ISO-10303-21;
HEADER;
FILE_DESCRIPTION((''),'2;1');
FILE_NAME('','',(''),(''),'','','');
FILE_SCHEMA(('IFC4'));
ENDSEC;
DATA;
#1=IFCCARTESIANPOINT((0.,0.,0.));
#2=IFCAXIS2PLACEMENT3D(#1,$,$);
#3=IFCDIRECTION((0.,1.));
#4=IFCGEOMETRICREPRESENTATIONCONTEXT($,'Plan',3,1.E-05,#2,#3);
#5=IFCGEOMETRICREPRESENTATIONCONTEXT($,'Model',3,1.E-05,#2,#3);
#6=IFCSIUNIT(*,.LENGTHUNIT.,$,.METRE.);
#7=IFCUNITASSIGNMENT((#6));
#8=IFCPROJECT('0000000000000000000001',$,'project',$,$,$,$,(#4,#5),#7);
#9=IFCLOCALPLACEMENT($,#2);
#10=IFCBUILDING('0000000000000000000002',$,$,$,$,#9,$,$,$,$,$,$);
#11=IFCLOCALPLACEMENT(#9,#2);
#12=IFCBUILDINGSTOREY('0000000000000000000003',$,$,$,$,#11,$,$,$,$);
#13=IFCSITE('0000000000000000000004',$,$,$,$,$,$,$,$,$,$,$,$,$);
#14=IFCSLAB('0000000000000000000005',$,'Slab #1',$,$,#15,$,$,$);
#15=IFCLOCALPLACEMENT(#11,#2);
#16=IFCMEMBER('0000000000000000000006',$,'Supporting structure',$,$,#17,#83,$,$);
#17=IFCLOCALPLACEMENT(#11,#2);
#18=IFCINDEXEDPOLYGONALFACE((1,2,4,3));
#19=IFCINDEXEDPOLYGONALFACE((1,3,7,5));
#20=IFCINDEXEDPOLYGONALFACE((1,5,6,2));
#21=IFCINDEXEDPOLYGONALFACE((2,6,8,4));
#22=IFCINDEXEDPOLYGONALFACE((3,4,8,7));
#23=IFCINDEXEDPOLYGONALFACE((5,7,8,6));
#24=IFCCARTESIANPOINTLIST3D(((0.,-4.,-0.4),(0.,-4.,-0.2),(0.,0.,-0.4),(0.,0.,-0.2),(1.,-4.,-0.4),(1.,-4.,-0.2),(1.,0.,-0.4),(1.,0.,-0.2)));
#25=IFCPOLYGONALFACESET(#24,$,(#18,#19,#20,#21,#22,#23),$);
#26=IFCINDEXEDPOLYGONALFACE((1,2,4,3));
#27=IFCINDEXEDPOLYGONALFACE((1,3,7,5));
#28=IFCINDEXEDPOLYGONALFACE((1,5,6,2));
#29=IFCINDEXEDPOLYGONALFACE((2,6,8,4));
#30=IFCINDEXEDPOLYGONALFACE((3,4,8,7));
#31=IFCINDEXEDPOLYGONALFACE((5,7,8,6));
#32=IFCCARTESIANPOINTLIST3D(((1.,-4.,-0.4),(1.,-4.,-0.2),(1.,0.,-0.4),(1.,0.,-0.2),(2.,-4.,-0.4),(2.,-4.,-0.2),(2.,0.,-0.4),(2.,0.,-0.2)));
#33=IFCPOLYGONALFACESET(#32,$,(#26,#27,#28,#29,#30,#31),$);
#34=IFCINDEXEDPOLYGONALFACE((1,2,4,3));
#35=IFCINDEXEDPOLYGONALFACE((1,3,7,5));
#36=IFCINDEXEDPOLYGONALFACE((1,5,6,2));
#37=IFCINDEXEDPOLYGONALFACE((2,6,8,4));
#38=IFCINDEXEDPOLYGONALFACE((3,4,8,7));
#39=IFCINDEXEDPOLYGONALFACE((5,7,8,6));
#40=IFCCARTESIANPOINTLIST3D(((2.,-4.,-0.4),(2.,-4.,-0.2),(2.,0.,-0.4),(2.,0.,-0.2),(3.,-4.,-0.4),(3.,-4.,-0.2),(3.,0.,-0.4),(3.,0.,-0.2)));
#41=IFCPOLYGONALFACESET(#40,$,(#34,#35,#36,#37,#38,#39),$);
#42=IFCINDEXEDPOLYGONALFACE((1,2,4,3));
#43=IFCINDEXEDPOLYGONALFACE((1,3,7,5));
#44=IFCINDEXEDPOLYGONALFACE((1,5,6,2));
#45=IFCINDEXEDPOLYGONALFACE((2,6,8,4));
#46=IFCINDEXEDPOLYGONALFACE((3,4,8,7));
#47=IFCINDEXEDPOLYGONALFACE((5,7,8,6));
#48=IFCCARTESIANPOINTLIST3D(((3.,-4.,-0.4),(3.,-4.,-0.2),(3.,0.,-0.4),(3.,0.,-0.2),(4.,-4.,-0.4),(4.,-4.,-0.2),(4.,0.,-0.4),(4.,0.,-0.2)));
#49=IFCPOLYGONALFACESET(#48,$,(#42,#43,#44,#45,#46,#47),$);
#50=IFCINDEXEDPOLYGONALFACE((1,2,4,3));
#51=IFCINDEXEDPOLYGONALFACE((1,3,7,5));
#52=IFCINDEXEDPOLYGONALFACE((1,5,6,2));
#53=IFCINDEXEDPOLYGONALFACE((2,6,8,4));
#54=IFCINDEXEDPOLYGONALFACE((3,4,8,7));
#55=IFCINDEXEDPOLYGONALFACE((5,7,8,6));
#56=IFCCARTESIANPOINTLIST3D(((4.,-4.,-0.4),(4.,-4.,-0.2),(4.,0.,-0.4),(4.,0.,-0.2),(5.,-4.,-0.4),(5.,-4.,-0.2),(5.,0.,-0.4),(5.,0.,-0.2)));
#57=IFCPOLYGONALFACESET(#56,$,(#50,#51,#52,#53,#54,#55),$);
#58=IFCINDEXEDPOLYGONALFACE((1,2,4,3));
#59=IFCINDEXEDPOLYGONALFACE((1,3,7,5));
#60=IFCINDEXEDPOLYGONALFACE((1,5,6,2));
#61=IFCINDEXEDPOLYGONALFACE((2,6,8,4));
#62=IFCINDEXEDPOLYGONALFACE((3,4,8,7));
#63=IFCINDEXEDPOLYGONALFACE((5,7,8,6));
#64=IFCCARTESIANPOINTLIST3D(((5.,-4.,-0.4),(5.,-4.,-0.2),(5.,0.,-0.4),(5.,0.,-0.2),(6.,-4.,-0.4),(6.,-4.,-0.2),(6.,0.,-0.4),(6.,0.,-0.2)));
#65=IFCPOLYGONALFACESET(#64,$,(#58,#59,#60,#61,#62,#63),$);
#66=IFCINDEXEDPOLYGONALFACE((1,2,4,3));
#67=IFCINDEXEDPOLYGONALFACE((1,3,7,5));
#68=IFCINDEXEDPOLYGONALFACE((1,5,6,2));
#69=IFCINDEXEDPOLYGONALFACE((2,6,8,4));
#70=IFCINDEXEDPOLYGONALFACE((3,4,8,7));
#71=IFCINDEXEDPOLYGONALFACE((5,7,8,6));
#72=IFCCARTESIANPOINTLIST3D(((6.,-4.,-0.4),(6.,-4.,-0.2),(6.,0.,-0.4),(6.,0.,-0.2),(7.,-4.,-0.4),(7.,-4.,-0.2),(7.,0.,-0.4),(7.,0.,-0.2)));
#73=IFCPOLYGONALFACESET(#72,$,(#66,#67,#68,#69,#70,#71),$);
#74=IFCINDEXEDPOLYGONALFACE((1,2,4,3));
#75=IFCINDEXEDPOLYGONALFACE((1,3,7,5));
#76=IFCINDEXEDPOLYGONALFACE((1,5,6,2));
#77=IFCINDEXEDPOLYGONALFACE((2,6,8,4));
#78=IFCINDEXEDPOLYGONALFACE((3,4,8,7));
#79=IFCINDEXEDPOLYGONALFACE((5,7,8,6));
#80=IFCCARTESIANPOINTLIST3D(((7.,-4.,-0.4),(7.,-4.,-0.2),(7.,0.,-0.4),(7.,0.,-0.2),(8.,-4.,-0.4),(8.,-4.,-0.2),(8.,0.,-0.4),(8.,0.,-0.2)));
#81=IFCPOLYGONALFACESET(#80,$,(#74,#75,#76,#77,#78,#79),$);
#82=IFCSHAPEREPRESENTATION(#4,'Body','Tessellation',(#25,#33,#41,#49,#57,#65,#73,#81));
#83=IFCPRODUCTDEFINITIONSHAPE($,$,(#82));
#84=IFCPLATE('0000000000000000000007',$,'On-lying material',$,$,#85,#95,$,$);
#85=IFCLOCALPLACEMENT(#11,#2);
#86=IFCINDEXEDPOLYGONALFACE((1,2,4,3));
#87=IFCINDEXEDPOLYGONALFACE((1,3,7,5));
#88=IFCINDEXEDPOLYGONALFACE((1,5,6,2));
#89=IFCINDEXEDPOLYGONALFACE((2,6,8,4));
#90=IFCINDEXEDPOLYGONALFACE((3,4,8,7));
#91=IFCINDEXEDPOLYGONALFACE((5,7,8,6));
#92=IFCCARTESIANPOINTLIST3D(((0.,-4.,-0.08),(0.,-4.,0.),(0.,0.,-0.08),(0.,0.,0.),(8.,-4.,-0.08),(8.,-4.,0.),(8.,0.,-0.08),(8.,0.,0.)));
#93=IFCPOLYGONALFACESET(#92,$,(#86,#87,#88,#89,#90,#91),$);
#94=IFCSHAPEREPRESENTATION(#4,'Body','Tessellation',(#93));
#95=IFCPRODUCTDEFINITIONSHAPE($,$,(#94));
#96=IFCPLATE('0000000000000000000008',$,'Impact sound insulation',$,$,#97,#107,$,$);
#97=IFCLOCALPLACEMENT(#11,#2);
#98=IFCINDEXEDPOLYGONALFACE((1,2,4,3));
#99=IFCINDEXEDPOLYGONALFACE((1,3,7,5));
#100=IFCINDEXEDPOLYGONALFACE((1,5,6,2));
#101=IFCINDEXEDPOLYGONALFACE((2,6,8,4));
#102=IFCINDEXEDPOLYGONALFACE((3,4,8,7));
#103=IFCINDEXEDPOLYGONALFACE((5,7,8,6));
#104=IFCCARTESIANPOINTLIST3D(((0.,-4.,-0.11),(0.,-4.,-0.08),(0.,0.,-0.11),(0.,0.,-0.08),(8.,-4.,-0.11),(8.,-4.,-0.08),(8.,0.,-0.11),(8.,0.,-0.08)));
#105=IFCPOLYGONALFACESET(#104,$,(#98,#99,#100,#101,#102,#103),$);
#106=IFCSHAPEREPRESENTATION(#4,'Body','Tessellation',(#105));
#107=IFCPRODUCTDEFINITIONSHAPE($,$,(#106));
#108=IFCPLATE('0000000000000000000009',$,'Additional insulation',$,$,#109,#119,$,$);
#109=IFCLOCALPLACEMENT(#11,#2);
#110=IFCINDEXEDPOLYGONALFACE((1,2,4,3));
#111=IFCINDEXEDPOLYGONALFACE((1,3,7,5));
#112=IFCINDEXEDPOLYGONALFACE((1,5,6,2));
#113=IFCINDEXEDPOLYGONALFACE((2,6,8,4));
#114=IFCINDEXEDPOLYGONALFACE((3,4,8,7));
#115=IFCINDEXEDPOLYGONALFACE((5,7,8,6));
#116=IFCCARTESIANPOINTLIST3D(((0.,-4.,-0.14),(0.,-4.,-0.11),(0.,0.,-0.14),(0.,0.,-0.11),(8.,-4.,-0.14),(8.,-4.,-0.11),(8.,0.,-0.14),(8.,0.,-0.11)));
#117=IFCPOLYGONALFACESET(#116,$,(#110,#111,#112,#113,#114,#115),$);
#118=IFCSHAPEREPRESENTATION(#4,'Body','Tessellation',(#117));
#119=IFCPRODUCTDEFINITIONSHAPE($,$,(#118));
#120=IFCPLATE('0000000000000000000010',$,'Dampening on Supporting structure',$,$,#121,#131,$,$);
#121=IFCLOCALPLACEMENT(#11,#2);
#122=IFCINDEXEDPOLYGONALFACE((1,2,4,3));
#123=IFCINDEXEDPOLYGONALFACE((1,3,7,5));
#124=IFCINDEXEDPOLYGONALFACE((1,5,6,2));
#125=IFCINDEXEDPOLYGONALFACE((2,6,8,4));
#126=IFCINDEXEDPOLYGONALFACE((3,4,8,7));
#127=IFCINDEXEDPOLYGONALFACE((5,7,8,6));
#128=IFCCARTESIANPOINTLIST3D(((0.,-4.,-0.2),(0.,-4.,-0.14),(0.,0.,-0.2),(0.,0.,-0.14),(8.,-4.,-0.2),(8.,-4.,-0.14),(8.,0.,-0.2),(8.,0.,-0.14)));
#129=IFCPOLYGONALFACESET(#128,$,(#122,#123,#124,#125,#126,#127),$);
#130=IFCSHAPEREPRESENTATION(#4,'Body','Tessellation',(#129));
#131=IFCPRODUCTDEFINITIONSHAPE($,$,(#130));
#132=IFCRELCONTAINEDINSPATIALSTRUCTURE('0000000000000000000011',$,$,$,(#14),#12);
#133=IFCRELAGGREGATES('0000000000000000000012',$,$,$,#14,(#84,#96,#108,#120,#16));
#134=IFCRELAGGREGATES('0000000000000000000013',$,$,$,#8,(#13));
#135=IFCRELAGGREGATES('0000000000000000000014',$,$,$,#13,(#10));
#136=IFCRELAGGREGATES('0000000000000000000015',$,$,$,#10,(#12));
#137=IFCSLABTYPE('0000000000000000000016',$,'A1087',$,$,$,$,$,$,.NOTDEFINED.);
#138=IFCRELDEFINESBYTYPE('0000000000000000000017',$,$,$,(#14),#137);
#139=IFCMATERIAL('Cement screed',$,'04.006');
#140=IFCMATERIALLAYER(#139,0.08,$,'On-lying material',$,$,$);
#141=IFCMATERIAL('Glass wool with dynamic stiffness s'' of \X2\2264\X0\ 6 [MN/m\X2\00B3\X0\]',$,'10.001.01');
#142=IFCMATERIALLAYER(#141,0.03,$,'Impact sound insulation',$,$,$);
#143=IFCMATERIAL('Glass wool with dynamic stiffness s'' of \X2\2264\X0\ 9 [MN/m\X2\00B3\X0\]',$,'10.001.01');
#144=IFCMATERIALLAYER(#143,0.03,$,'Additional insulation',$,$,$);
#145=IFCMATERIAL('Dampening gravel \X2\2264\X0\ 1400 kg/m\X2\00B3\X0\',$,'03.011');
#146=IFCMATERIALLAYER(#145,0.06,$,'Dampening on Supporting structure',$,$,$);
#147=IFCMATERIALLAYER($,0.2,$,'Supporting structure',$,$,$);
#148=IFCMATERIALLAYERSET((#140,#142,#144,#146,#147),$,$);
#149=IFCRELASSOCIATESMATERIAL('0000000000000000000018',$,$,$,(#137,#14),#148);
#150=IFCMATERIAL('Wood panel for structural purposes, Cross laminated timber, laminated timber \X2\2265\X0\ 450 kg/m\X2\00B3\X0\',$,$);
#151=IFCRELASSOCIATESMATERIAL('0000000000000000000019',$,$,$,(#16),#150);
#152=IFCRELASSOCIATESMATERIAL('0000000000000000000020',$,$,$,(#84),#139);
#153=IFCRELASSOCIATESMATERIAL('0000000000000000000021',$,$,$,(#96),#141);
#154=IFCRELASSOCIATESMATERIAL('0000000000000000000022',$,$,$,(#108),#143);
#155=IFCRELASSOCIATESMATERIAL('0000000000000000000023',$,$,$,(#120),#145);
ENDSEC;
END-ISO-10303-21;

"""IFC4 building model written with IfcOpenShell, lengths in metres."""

from ifc_helpers import new_model, si_unit, direction, frame, frame_2d, origin, origin_with_axes, place, context, project, spatial, rectangle, extrude, material, layer, layer_set, type_object, element, aggregate, save


model = new_model("IFC4")

# Units and contexts
plan_context = context("Plan", 3, precision=1e-05, world=origin(), true_north=direction((0.0, 1.0)))
model_context = context("Model", 3, precision=1e-05, world=origin(), true_north=direction((0.0, 1.0)))
ifc_project = project(units=[si_unit("LENGTHUNIT", "METRE")], contexts=[plan_context, model_context])

# Site, building, storey
site = spatial("IfcSite", under=ifc_project)
building_placement = place(None, origin())
building = spatial("IfcBuilding", under=site, at=building_placement)
storey_placement = place(building_placement, origin())
storey = spatial("IfcBuildingStorey", under=building, at=storey_placement)

# Slab, member, plates
ifc_material_1 = material(Name="Cement screed", Category="04.006")
ifc_layer_1 = layer(ifc_material_1, 0.08, Name="On-lying material")
ifc_material_2 = material(Name="Glass wool with dynamic stiffness s' of ≤ 6 [MN/m³]", Category="10.001.01")
ifc_layer_2 = layer(ifc_material_2, 0.03, Name="Impact sound insulation")
ifc_material_3 = material(Name="Glass wool with dynamic stiffness s' of ≤ 9 [MN/m³]", Category="10.001.01")
ifc_layer_3 = layer(ifc_material_3, 0.03, Name="Additional insulation")
ifc_material_4 = material(Name="Dampening gravel ≤ 1400 kg/m³", Category="03.011")
ifc_layer_4 = layer(ifc_material_4, 0.06, Name="Dampening on Supporting structure")
ifc_layer_5 = layer(None, 0.2, Name="Supporting structure")
ifc_layer_set = layer_set([ifc_layer_1, ifc_layer_2, ifc_layer_3, ifc_layer_4, ifc_layer_5])
slab_type = type_object("IfcSlabType", Name="A1087", PredefinedType="NOTDEFINED", material=ifc_layer_set)
slab_placement = place(None, frame((0.0, 0.0, 0.0), z_axis=(0.0, 0.0, -1.0), x_axis=(1.0, 0.0, 0.0)))
slab = element("IfcSlab", 1, at=slab_placement, inside=storey, type_object=slab_type, material=ifc_layer_set, Name="Slab #1")
ifc_material_5 = material(Name="Wood panel for structural purposes, Cross laminated timber, laminated timber ≥ 450 kg/m³")
member_placement = place(slab_placement, origin())
member = element("IfcMember", 2, at=member_placement, material=ifc_material_5, Name="Supporting structure", context=plan_context, shape_type="SweptSolid", body=[
    extrude(rectangle(XDim=1.0, YDim=0.2, at=frame_2d((0.5, 0.1), x_axis=(1.0, 0.0))), frame((0.0, 4.0, 0.2), z_axis=(0.0, -1.0, 0.0), x_axis=(1.0, 0.0, 0.0)), (0.0, 0.0, 1.0), 4.0),
    extrude(rectangle(XDim=1.0, YDim=0.2, at=frame_2d((0.5, 0.1), x_axis=(1.0, 0.0))), frame((1.0, 4.0, 0.2), z_axis=(0.0, -1.0, 0.0), x_axis=(1.0, 0.0, 0.0)), (0.0, 0.0, 1.0), 4.0),
    extrude(rectangle(XDim=1.0, YDim=0.2, at=frame_2d((0.5, 0.1), x_axis=(1.0, 0.0))), frame((2.0, 4.0, 0.2), z_axis=(0.0, -1.0, 0.0), x_axis=(1.0, 0.0, 0.0)), (0.0, 0.0, 1.0), 4.0),
    extrude(rectangle(XDim=1.0, YDim=0.2, at=frame_2d((0.5, 0.1), x_axis=(1.0, 0.0))), frame((3.0, 4.0, 0.2), z_axis=(0.0, -1.0, 0.0), x_axis=(1.0, 0.0, 0.0)), (0.0, 0.0, 1.0), 4.0),
    extrude(rectangle(XDim=1.0, YDim=0.2, at=frame_2d((0.5, 0.1), x_axis=(1.0, 0.0))), frame((4.0, 4.0, 0.2), z_axis=(0.0, -1.0, 0.0), x_axis=(1.0, 0.0, 0.0)), (0.0, 0.0, 1.0), 4.0),
    extrude(rectangle(XDim=1.0, YDim=0.2, at=frame_2d((0.5, 0.1), x_axis=(1.0, 0.0))), frame((5.0, 4.0, 0.2), z_axis=(0.0, -1.0, 0.0), x_axis=(1.0, 0.0, 0.0)), (0.0, 0.0, 1.0), 4.0),
    extrude(rectangle(XDim=1.0, YDim=0.2, at=frame_2d((0.5, 0.1), x_axis=(1.0, 0.0))), frame((6.0, 4.0, 0.2), z_axis=(0.0, -1.0, 0.0), x_axis=(1.0, 0.0, 0.0)), (0.0, 0.0, 1.0), 4.0),
    extrude(rectangle(XDim=1.0, YDim=0.2, at=frame_2d((0.5, 0.1), x_axis=(1.0, 0.0))), frame((7.0, 4.0, 0.2), z_axis=(0.0, -1.0, 0.0), x_axis=(1.0, 0.0, 0.0)), (0.0, 0.0, 1.0), 4.0),
])
plate_1_placement = place(slab_placement, origin())
plate_1 = element("IfcPlate", 3, at=plate_1_placement, material=ifc_material_1, Name="On-lying material", context=plan_context, shape_type="SweptSolid", body=[
    extrude(rectangle(XDim=8.0, YDim=4.0, at=frame_2d((4.0, 2.0), x_axis=(1.0, 0.0))), origin_with_axes(), (0.0, 0.0, 1.0), 0.08),
])
plate_2_placement = place(slab_placement, origin())
plate_2 = element("IfcPlate", 4, at=plate_2_placement, material=ifc_material_2, Name="Impact sound insulation", context=plan_context, shape_type="SweptSolid", body=[
    extrude(rectangle(XDim=8.0, YDim=4.0, at=frame_2d((4.0, 2.0), x_axis=(1.0, 0.0))), frame((0.0, 0.0, 0.08), z_axis=(0.0, 0.0, 1.0), x_axis=(1.0, 0.0, 0.0)), (0.0, 0.0, 1.0), 0.03),
])
plate_3_placement = place(slab_placement, origin())
plate_3 = element("IfcPlate", 5, at=plate_3_placement, material=ifc_material_3, Name="Additional insulation", context=plan_context, shape_type="SweptSolid", body=[
    extrude(rectangle(XDim=8.0, YDim=4.0, at=frame_2d((4.0, 2.0), x_axis=(1.0, 0.0))), frame((0.0, 0.0, 0.11), z_axis=(0.0, 0.0, 1.0), x_axis=(1.0, 0.0, 0.0)), (0.0, 0.0, 1.0), 0.03),
])
plate_4_placement = place(slab_placement, origin())
plate_4 = element("IfcPlate", 6, at=plate_4_placement, material=ifc_material_4, Name="Dampening on Supporting structure", context=plan_context, shape_type="SweptSolid", body=[
    extrude(rectangle(XDim=8.0, YDim=4.0, at=frame_2d((4.0, 2.0), x_axis=(1.0, 0.0))), frame((0.0, 0.0, 0.14), z_axis=(0.0, 0.0, 1.0), x_axis=(1.0, 0.0, 0.0)), (0.0, 0.0, 1.0), 0.06),
])
aggregate(slab, [plate_1, plate_2, plate_3, plate_4, member])

save(model, "model.ifc")
